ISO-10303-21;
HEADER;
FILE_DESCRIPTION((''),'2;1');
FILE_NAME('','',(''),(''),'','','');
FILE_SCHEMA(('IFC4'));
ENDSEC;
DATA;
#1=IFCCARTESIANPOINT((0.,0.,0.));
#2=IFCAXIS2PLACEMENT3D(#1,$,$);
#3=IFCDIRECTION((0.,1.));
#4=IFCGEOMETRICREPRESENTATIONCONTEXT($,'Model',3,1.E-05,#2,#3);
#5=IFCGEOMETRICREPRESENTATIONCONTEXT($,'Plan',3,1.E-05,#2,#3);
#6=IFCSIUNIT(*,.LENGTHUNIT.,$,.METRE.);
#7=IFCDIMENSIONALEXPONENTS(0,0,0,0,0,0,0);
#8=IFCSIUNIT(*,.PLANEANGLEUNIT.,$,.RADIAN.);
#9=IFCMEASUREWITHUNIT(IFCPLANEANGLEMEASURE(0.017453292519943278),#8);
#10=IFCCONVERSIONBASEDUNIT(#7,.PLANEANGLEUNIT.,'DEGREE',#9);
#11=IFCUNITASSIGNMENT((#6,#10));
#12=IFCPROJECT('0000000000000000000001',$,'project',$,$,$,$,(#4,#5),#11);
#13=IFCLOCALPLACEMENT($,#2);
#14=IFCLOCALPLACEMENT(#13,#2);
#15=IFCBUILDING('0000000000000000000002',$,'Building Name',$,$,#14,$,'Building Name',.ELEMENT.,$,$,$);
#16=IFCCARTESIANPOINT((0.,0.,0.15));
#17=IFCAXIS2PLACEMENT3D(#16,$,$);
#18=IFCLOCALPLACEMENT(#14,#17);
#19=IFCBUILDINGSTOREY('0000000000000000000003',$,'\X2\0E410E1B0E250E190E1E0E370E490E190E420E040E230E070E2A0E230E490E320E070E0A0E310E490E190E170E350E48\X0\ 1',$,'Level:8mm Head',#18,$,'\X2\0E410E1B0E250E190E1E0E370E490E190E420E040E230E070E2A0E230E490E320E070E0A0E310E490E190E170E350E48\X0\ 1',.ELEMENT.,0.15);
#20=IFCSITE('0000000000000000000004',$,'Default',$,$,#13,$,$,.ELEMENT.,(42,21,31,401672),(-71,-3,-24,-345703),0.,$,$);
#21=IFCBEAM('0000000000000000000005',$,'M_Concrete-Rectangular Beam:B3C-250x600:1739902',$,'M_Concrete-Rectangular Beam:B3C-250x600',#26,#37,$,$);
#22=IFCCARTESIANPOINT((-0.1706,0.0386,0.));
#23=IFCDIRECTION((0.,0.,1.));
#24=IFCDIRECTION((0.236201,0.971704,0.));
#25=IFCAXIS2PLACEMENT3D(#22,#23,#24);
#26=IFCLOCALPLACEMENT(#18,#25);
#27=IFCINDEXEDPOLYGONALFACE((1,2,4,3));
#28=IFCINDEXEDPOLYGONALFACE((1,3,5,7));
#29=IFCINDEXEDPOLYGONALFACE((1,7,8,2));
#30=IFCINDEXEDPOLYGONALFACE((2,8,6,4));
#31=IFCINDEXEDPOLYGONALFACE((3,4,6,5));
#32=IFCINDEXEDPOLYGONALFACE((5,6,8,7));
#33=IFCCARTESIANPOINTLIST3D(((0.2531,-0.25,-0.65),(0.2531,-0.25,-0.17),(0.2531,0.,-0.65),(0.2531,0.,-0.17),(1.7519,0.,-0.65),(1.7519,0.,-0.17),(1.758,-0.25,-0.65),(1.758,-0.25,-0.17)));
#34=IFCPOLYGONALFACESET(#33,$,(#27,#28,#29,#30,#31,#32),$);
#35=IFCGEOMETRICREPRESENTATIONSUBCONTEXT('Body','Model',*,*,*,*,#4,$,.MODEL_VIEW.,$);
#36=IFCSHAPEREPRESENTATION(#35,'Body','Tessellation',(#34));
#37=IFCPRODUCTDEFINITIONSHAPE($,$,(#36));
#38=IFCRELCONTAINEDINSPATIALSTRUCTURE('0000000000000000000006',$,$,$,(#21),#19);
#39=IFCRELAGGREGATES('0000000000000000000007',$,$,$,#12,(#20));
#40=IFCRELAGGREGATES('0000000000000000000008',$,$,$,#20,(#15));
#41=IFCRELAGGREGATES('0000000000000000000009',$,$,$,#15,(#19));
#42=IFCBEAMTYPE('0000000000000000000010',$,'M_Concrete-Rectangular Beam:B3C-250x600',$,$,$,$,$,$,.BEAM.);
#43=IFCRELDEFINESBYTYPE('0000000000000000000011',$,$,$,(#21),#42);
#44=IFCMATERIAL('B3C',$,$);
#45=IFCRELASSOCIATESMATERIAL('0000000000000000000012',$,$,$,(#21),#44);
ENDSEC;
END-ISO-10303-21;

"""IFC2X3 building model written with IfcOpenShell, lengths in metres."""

from ifc_helpers import new_model, entity, si_unit, converted_unit, direction, frame, frame_2d, origin, place, context, subcontext, project, spatial, rectangle, extrude, clip, halfspace, material, type_object, element, save


model = new_model("IFC2X3")

# Units and contexts
model_context = context("Model", 3, precision=1e-05, world=origin(), true_north=direction((0.0, 1.0)))
plan_context = context("Plan", 3, precision=1e-05, world=origin(), true_north=direction((0.0, 1.0)))
body_context = subcontext(model_context, "Body", "Model", "MODEL_VIEW")
ifc_project = project(units=[si_unit("LENGTHUNIT", "METRE"), converted_unit("PLANEANGLEUNIT", "DEGREE", entity("IfcPlaneAngleMeasure", 0.017453292519943278), si_unit("PLANEANGLEUNIT", "RADIAN"), dimensions=[0, 0, 0, 0, 0, 0, 0])], contexts=[model_context, plan_context])

# Site, building, storey
site_placement = place(None, origin())
site = spatial("IfcSite", under=ifc_project, at=site_placement, Name="Default", CompositionType="ELEMENT", RefLatitude=(42, 21, 31, 401672), RefLongitude=(-71, -3, -24, -345703), RefElevation=0.0)
building_placement = place(site_placement, origin())
building = spatial("IfcBuilding", under=site, at=building_placement, Name="Building Name", LongName="Building Name", CompositionType="ELEMENT")
storey_placement = place(building_placement, frame((0.0, 0.0, 0.15)))
storey = spatial("IfcBuildingStorey", under=building, at=storey_placement, Name="แปลนพื้นโครงสร้างชั้นที่ 1", ObjectType="Level:8mm Head", LongName="แปลนพื้นโครงสร้างชั้นที่ 1", CompositionType="ELEMENT", Elevation=0.15)

# Beam
ifc_material_1 = material(Name="B3C")
beam_type_1 = type_object("IfcBeamType", Name="M_Concrete-Rectangular Beam:B3C-250x600", PredefinedType="BEAM")
beam_1_placement = place(storey_placement, frame((-0.1706, 0.0386, 0.0), z_axis=(0.0, 0.0, 1.0), x_axis=(0.236201, 0.971704, 0.0)))
element("IfcBeam", 1, at=beam_1_placement, inside=storey, type_object=beam_type_1, material=ifc_material_1, Name="M_Concrete-Rectangular Beam:B3C-250x600:1739902", ObjectType="M_Concrete-Rectangular Beam:B3C-250x600", context=body_context, shape_type="Clipping", body=[
    clip(extrude(rectangle(XDim=0.48, YDim=0.25, at=frame_2d((0.0, 0.0), x_axis=(1.0, 0.0))), frame((0.2531, -0.125, -0.41), z_axis=(1.0, 0.0, 0.0), x_axis=(0.0, 0.0, -1.0)), (0.0, 0.0, 1.0), 1.5049), halfspace(frame((1.7513, 0.0241, -0.05), z_axis=(0.999703, 0.024378, 0.0), x_axis=(0.024378, -0.999703, 0.0)), False)),
])

save(model, "model.ifc")
